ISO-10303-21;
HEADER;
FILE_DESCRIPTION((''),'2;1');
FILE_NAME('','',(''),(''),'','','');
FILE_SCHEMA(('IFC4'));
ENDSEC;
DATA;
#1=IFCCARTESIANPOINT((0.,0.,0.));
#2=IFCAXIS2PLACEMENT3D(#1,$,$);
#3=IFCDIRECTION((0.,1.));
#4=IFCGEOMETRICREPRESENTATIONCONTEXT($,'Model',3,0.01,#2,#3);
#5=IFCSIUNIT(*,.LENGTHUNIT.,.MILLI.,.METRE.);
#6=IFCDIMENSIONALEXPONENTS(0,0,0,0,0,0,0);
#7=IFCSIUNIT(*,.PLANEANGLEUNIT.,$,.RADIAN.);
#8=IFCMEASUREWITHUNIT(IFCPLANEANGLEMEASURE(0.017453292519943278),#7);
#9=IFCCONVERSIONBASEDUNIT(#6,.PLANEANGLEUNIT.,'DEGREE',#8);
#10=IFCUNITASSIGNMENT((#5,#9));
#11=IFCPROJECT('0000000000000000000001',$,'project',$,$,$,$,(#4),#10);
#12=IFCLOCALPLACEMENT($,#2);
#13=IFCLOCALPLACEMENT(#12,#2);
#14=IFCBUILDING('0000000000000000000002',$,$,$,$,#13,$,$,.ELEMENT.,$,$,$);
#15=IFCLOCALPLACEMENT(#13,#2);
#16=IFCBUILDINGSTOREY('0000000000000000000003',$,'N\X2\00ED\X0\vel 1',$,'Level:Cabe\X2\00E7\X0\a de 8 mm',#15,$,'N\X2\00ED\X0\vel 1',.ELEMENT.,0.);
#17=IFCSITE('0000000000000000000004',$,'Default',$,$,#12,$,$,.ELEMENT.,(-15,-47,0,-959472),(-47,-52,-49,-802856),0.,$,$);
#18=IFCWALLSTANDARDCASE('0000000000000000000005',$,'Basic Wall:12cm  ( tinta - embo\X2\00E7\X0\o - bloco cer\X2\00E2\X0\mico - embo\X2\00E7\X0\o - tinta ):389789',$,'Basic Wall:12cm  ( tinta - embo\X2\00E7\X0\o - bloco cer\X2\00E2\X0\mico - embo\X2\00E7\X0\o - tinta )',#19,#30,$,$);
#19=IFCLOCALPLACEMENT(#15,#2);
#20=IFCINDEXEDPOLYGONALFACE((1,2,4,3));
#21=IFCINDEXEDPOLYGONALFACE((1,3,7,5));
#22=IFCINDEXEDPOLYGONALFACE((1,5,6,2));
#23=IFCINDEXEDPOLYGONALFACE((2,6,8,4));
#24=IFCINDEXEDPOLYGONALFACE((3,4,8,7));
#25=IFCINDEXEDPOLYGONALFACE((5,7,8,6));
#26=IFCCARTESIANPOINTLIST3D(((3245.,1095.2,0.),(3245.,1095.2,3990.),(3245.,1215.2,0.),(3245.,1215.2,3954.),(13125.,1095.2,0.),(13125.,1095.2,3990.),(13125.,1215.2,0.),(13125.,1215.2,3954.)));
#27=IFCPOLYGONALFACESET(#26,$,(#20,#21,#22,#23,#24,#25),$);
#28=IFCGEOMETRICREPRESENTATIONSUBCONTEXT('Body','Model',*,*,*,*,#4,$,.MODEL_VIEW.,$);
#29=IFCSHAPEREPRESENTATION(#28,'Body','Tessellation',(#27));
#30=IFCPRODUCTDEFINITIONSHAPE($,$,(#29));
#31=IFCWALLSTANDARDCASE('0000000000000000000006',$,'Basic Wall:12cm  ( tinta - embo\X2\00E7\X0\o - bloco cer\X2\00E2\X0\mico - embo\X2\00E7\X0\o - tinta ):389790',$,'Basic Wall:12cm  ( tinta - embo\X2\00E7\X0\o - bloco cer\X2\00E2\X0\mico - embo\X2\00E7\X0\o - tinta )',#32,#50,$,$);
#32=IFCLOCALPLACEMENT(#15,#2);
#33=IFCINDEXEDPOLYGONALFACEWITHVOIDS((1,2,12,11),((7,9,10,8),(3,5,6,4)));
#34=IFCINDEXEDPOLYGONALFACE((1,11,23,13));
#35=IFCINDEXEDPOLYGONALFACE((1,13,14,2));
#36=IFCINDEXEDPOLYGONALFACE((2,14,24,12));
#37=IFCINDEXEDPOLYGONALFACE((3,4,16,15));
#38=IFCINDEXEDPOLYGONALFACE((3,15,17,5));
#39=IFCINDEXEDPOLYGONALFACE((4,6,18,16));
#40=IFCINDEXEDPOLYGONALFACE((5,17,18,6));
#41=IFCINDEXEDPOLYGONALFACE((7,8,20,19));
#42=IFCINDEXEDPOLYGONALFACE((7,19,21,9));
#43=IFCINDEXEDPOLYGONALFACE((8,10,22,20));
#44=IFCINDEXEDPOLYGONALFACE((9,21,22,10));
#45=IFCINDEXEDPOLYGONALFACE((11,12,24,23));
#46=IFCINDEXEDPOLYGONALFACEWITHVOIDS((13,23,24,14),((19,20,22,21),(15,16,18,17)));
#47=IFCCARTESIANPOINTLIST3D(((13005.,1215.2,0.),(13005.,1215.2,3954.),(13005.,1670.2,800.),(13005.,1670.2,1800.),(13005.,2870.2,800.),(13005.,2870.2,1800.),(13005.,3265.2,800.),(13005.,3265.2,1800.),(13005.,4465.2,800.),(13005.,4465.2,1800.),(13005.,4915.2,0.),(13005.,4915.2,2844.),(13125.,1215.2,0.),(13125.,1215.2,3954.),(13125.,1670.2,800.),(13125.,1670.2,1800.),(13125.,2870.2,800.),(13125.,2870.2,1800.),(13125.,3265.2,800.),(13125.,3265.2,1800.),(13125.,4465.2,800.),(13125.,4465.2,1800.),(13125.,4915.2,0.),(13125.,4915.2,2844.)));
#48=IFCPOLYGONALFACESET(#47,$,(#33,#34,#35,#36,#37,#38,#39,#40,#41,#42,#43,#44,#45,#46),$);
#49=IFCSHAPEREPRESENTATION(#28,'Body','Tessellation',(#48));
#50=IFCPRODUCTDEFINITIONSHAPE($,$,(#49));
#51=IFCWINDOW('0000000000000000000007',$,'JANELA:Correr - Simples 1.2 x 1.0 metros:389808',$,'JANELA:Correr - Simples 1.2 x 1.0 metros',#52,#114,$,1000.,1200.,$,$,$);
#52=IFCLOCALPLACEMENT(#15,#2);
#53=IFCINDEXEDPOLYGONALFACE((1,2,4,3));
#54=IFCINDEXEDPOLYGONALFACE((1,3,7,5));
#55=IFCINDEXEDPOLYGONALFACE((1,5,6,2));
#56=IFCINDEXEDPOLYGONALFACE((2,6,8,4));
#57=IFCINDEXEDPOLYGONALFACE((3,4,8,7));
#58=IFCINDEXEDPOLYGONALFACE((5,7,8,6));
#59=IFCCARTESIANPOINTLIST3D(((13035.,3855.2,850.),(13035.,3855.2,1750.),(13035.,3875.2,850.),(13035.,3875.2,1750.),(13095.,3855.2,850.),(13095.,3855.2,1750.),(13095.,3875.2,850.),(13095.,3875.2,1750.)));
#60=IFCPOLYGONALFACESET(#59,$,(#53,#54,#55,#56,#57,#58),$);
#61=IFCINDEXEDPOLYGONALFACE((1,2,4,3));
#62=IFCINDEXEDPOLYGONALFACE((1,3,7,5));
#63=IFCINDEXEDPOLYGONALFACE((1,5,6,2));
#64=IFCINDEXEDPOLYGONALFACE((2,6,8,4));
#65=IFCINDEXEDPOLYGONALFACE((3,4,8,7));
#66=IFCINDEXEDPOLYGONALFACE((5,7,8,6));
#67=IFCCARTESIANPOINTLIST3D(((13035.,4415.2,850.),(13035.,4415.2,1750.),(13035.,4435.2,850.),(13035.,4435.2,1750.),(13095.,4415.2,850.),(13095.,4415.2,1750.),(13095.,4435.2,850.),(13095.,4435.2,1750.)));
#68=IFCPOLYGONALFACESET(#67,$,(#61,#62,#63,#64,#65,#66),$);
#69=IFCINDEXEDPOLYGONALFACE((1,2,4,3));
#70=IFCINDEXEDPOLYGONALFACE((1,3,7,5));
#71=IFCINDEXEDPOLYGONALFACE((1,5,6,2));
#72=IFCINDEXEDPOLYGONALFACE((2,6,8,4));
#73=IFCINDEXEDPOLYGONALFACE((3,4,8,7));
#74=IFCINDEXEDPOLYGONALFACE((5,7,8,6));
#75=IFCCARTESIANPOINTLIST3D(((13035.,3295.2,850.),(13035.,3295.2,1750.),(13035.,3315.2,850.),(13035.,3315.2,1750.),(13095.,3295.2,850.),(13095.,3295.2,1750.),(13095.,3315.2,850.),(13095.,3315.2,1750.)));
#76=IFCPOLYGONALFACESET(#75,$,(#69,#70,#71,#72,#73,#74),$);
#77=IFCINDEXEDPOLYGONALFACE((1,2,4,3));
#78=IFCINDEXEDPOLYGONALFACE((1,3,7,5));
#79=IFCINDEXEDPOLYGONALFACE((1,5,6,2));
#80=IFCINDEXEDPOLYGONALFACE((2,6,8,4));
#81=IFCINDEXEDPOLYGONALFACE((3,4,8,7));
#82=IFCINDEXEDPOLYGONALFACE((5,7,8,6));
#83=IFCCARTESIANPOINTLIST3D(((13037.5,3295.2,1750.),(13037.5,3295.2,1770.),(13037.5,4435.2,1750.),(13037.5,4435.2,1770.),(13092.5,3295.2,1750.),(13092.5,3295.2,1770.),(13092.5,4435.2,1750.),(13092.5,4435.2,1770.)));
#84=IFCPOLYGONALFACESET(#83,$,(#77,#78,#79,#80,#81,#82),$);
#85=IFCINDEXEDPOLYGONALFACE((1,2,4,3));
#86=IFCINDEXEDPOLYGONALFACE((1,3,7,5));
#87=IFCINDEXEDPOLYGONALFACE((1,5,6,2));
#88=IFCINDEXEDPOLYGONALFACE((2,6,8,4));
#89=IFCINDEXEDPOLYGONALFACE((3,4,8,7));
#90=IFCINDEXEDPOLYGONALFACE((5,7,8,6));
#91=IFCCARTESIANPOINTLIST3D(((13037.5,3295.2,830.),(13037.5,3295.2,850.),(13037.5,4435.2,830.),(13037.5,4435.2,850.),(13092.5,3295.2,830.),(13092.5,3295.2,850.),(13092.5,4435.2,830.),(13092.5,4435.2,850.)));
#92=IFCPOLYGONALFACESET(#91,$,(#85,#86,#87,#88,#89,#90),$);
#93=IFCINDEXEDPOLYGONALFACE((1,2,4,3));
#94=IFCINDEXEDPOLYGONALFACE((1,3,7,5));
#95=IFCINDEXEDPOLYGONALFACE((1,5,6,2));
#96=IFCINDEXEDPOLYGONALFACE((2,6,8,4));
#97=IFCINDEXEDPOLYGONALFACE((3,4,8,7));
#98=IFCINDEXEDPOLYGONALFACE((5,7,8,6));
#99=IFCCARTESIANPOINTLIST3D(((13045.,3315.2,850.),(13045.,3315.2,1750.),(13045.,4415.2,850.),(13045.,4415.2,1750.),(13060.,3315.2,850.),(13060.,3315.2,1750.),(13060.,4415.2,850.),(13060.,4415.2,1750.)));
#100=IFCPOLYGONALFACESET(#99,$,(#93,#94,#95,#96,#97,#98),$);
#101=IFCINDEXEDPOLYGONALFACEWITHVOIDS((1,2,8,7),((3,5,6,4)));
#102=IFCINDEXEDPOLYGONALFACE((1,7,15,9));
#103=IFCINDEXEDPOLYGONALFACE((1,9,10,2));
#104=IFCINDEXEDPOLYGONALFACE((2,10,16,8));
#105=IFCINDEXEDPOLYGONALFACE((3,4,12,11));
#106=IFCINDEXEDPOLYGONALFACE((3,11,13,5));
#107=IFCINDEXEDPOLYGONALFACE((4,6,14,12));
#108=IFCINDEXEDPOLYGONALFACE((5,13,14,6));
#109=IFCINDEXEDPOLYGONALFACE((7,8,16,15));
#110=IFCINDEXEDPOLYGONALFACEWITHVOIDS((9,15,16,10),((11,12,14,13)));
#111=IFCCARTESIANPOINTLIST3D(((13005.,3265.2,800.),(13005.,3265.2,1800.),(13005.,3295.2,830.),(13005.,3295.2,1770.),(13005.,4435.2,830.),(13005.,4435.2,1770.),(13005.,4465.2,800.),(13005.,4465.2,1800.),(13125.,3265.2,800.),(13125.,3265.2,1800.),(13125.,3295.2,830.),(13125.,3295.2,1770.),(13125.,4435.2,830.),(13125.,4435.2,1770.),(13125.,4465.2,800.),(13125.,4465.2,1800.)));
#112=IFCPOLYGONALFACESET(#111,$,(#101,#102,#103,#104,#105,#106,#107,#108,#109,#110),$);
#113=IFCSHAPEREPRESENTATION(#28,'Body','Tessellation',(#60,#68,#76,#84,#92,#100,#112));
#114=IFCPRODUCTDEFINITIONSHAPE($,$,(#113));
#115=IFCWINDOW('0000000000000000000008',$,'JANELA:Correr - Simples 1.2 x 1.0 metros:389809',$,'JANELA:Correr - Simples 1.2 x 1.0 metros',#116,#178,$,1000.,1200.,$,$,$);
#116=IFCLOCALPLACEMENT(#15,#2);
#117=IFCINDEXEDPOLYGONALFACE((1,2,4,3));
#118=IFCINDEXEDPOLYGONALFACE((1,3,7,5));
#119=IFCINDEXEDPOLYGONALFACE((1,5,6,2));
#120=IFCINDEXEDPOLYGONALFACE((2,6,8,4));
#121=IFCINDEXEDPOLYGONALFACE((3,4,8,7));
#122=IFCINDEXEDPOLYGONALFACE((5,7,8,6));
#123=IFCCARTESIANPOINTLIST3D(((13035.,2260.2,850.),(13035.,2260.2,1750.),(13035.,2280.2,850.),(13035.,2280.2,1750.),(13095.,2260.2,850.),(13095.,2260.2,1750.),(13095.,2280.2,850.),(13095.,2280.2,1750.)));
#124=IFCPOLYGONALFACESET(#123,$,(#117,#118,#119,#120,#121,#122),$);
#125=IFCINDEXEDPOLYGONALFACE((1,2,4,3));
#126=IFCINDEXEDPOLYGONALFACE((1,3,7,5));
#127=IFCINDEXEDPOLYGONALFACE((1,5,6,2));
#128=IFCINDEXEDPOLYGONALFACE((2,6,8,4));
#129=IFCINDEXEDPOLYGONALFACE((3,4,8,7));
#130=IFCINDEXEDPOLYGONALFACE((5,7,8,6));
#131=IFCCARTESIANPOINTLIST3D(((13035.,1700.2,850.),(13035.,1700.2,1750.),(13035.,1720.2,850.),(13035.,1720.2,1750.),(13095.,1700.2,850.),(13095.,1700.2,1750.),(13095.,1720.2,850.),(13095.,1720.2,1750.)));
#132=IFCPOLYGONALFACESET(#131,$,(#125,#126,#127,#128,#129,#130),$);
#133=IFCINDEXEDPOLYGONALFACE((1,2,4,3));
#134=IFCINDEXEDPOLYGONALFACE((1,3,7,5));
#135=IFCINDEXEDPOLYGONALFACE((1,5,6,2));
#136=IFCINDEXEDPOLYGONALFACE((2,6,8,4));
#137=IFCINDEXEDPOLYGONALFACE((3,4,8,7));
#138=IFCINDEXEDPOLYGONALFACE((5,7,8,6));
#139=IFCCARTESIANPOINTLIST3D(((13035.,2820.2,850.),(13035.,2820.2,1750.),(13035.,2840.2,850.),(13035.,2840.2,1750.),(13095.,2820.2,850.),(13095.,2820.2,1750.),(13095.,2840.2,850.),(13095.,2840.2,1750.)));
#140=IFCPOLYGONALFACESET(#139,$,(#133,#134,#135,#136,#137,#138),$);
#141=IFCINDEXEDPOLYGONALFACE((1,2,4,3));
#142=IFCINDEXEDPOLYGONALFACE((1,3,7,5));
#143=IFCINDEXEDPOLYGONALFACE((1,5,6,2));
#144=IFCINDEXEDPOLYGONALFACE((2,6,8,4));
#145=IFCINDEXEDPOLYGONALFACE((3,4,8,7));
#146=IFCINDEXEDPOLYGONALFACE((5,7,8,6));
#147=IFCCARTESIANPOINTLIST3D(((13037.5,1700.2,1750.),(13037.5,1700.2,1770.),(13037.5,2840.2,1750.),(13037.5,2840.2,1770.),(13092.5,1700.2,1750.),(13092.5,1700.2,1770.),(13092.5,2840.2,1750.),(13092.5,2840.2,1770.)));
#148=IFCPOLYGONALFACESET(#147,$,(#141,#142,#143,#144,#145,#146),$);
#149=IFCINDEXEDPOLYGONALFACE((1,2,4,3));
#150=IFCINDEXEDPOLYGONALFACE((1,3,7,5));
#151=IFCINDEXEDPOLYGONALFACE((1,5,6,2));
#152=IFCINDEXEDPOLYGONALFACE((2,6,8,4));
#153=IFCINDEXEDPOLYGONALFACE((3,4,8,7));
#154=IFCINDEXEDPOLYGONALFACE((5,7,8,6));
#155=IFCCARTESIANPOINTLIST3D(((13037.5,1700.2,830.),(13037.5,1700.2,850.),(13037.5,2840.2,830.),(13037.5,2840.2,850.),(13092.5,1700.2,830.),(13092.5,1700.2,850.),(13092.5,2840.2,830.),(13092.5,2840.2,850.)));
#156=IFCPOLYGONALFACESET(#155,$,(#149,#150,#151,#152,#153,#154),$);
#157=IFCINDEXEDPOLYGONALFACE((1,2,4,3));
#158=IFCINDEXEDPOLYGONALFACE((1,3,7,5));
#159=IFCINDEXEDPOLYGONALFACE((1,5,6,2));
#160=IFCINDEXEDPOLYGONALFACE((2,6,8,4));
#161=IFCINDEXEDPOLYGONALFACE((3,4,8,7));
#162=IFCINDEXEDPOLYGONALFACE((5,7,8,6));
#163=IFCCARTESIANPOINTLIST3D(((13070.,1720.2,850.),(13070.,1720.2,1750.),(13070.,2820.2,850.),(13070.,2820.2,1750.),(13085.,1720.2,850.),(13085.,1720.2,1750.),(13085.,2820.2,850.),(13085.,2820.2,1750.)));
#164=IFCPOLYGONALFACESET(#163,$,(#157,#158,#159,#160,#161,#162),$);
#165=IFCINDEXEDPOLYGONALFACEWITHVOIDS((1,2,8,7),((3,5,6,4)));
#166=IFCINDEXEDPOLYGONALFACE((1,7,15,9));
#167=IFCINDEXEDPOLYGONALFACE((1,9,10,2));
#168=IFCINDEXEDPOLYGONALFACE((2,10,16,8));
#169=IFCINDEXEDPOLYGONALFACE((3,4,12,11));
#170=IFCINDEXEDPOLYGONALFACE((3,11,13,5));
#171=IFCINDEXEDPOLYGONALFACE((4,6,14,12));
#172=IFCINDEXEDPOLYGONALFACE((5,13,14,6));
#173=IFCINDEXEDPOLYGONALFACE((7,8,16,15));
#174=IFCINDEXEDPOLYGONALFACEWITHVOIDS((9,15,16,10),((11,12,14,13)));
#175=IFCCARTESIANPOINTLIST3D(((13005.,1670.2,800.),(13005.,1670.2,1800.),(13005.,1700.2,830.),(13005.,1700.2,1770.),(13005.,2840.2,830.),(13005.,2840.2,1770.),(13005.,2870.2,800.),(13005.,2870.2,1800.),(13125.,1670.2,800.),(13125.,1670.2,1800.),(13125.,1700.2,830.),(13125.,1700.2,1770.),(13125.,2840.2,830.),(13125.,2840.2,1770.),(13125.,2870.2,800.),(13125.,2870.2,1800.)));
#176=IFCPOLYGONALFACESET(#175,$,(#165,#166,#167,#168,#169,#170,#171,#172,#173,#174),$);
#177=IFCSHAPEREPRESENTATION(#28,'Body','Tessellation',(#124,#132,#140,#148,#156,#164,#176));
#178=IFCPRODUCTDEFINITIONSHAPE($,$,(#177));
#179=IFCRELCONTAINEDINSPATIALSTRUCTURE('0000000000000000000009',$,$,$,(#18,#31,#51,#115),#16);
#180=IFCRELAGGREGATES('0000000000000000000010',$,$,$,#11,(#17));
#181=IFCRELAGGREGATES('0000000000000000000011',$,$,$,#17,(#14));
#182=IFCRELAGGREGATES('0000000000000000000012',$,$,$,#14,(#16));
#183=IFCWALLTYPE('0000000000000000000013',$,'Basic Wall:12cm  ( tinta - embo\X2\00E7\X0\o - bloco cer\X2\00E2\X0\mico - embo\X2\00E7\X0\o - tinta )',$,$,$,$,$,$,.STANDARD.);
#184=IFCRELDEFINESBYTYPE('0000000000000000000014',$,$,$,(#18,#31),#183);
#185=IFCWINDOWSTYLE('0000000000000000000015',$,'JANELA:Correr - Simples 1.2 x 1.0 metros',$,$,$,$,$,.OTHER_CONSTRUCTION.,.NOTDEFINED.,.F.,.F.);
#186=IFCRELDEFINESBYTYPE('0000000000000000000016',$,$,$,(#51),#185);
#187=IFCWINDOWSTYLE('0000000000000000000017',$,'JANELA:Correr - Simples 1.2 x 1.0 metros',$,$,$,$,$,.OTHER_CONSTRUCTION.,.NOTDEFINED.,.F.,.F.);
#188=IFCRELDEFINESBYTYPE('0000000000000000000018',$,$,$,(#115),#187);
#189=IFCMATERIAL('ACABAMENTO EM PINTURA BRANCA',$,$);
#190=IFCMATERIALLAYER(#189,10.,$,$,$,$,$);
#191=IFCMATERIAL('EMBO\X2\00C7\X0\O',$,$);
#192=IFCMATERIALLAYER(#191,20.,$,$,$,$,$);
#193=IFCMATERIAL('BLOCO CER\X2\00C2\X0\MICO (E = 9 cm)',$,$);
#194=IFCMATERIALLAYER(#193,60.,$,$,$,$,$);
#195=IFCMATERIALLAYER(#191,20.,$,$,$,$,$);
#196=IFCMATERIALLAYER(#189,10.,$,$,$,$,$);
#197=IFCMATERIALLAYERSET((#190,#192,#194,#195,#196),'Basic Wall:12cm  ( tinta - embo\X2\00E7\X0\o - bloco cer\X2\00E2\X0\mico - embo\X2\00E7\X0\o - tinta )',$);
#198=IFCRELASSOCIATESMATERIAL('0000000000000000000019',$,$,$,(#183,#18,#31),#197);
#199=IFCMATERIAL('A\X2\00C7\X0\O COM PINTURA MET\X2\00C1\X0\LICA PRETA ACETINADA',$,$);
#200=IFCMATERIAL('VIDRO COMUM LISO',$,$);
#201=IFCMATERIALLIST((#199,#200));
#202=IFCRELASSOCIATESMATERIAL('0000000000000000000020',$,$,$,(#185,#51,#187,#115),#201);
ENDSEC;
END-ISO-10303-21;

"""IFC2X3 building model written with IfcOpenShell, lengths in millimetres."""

from ifc_helpers import new_model, entity, si_unit, converted_unit, direction, frame, frame_2d, origin, origin_2d_with_axis, place, context, subcontext, project, spatial, polyline, rectangle, outline, extrude, clip, bounded_halfspace, source, transform, mapped, material, material_list, layer, layer_set, layer_usage, type_object, type_shapes, element, fill, save


model = new_model("IFC2X3")

# Units and contexts
model_context = context("Model", 3, precision=0.01, world=origin(), true_north=direction((0.0, 1.0)))
body_context = subcontext(model_context, "Body", "Model", "MODEL_VIEW")
ifc_project = project(units=[si_unit("LENGTHUNIT", "METRE", prefix="MILLI"), converted_unit("PLANEANGLEUNIT", "DEGREE", entity("IfcPlaneAngleMeasure", 0.017453292519943278), si_unit("PLANEANGLEUNIT", "RADIAN"), dimensions=[0, 0, 0, 0, 0, 0, 0])], contexts=[model_context])

# Site, building, storey
site_placement = place(None, origin())
site = spatial("IfcSite", under=ifc_project, at=site_placement, Name="Default", CompositionType="ELEMENT", RefLatitude=(-15, -47, 0, -959472), RefLongitude=(-47, -52, -49, -802856), RefElevation=0.0)
building_placement = place(site_placement, origin())
building = spatial("IfcBuilding", under=site, at=building_placement, CompositionType="ELEMENT")
storey_placement = place(building_placement, origin())
storey = spatial("IfcBuildingStorey", under=building, at=storey_placement, Name="Nível 1", ObjectType="Level:Cabeça de 8 mm", LongName="Nível 1", CompositionType="ELEMENT", Elevation=0.0)

# Wall
ifc_material_1 = material(Name="ACABAMENTO EM PINTURA BRANCA")
ifc_layer_1 = layer(ifc_material_1, 10.0)
ifc_material_2 = material(Name="EMBOÇO")
ifc_layer_2 = layer(ifc_material_2, 20.0)
ifc_material_3 = material(Name="BLOCO CERÂMICO (E = 9 cm)")
ifc_layer_3 = layer(ifc_material_3, 60.0)
ifc_layer_4 = layer(ifc_material_2, 20.0)
ifc_layer_5 = layer(ifc_material_1, 10.0)
ifc_layer_set_1 = layer_set([ifc_layer_1, ifc_layer_2, ifc_layer_3, ifc_layer_4, ifc_layer_5], Name="Basic Wall:12cm  ( tinta - emboço - bloco cerâmico - emboço - tinta )")
ifc_layer_usage_1 = layer_usage(ifc_layer_set_1, "AXIS2", "NEGATIVE", 60.0)
wall_type_1 = type_object("IfcWallType", Name="Basic Wall:12cm  ( tinta - emboço - bloco cerâmico - emboço - tinta )", PredefinedType="STANDARD", material=ifc_layer_set_1)
wall_1_placement = place(storey_placement, frame((13125.0, 1155.2, 0.0), z_axis=(0.0, 0.0, 1.0), x_axis=(-1.0, 0.0, 0.0)))
element("IfcWallStandardCase", 1, at=wall_1_placement, inside=storey, type_object=wall_type_1, material=ifc_layer_usage_1, Name="Basic Wall:12cm  ( tinta - emboço - bloco cerâmico - emboço - tinta ):389789", ObjectType="Basic Wall:12cm  ( tinta - emboço - bloco cerâmico - emboço - tinta )", context=body_context, shape_type="Clipping", body=[
    clip(extrude(rectangle(XDim=9880.0, YDim=120.0, at=frame_2d((4940.0, 0.0), x_axis=(-1.0, 0.0))), origin(), (0.0, 0.0, 1.0), 3990.0), bounded_halfspace(frame((0.0, -60.0, 3954.0), z_axis=(0.0, -0.287348, 0.957826), x_axis=(1.0, 0.0, 0.0)), False, frame((0.0, -60.0, 3954.0)), polyline([(0.0, 0.0), (120.0, 0.0), (9880.0, 0.0), (9880.0, 120.0), (0.0, 120.0), (0.0, 0.0)]))),
])

# Wall, openings, windows
ifc_layer_usage_2 = layer_usage(ifc_layer_set_1, "AXIS2", "NEGATIVE", 60.0)
wall_2_placement = place(storey_placement, frame((13065.0, 1215.2, 0.0), z_axis=(0.0, 0.0, 1.0), x_axis=(0.0, 1.0, 0.0)))
wall_2 = element("IfcWallStandardCase", 2, at=wall_2_placement, inside=storey, type_object=wall_type_1, material=ifc_layer_usage_2, Name="Basic Wall:12cm  ( tinta - emboço - bloco cerâmico - emboço - tinta ):389790", ObjectType="Basic Wall:12cm  ( tinta - emboço - bloco cerâmico - emboço - tinta )", context=body_context, shape_type="Clipping", body=[
    clip(extrude(rectangle(XDim=3700.0, YDim=120.0, at=frame_2d((1850.0, 0.0), x_axis=(-1.0, 0.0))), origin(), (0.0, 0.0, 1.0), 3954.0), bounded_halfspace(frame((0.0, -60.0, 3954.0), z_axis=(0.287348, 0.0, 0.957826), x_axis=(0.0, 1.0, 0.0)), False, frame((0.0, -60.0, 3954.0)), polyline([(0.0, 0.0), (3700.0, 0.0), (3700.0, 120.0), (0.0, 120.0), (0.0, 0.0)]))),
])
opening_1_placement = place(wall_2_placement, frame((3250.0, 60.0, 800.0)))
opening_1 = element("IfcOpeningElement", 3, at=opening_1_placement, cuts=wall_2, ObjectType="Opening", context=body_context, shape_type="SweptSolid", body=[
    extrude(rectangle(XDim=1000.0, YDim=1200.0, at=frame_2d((500.0, 600.0), x_axis=(1.0, 0.0))), frame((0.0, 0.0, 0.0), z_axis=(0.0, -1.0, 0.0), x_axis=(0.0, 0.0, 1.0)), (0.0, 0.0, 1.0), 120.0),
])
opening_2_placement = place(wall_2_placement, frame((455.0, -60.0, 800.0)))
opening_2 = element("IfcOpeningElement", 4, at=opening_2_placement, cuts=wall_2, ObjectType="Opening", context=body_context, shape_type="SweptSolid", body=[
    extrude(rectangle(XDim=1000.0, YDim=1200.0, at=frame_2d((500.0, 600.0), x_axis=(1.0, 0.0))), frame((0.0, 0.0, 0.0), z_axis=(0.0, 1.0, 0.0), x_axis=(0.0, 0.0, 1.0)), (0.0, 0.0, 1.0), 120.0),
])
ifc_material_4 = material(Name="AÇO COM PINTURA METÁLICA PRETA ACETINADA")
ifc_material_5 = material(Name="VIDRO COMUM LISO")
ifc_material_list_1 = material_list([ifc_material_4, ifc_material_5])
window_style_1 = type_object("IfcWindowStyle", Name="JANELA:Correr - Simples 1.2 x 1.0 metros", ConstructionType="OTHER_CONSTRUCTION", OperationType="NOTDEFINED", ParameterTakesPrecedence=False, Sizeable=False, material=ifc_material_list_1)
shared_shape_1 = source(origin(), body_context, "Body", "SweptSolid", [
    extrude(rectangle(XDim=20.0, YDim=60.0, at=origin_2d_with_axis()), frame((600.0, 60.0, 50.0), z_axis=(0.0, 0.0, 1.0), x_axis=(-1.0, 0.0, 0.0)), (0.0, 0.0, 1.0), 900.0),
    extrude(rectangle(XDim=20.0, YDim=60.0, at=frame_2d((0.0, 0.0), x_axis=(1.0, 0.0))), frame((40.0, 60.0, 50.0), z_axis=(0.0, 0.0, 1.0), x_axis=(-1.0, 0.0, 0.0)), (0.0, 0.0, 1.0), 900.0),
    extrude(rectangle(XDim=20.0, YDim=60.0, at=frame_2d((0.0, 0.0), x_axis=(1.0, 0.0))), frame((1160.0, 60.0, 50.0), z_axis=(0.0, 0.0, 1.0), x_axis=(-1.0, 0.0, 0.0)), (0.0, 0.0, 1.0), 900.0),
    extrude(rectangle(XDim=1140.0, YDim=55.0, at=origin_2d_with_axis()), frame((600.0, 60.0, 950.0), z_axis=(0.0, 0.0, 1.0), x_axis=(-1.0, 0.0, 0.0)), (0.0, 0.0, 1.0), 20.0),
    extrude(rectangle(XDim=1140.0, YDim=55.0, at=origin_2d_with_axis()), frame((600.0, 60.0, 30.0), z_axis=(0.0, 0.0, 1.0), x_axis=(-1.0, 0.0, 0.0)), (0.0, 0.0, 1.0), 20.0),
    extrude(rectangle(XDim=15.0, YDim=1100.0, at=frame_2d((0.0, 0.0), x_axis=(1.0, 0.0))), frame((600.0, 47.5, 50.0), z_axis=(0.0, 0.0, 1.0), x_axis=(0.0, 1.0, 0.0)), (0.0, 0.0, 1.0), 900.0),
    extrude(outline(polyline([(-600.0, -500.0), (600.0, -500.0), (600.0, 500.0), (-600.0, 500.0), (-600.0, -500.0)]), holes=[polyline([(570.0, -470.0), (-570.0, -470.0), (-570.0, 470.0), (570.0, 470.0), (570.0, -470.0)])]), frame((600.0, 0.0, 500.0), z_axis=(0.0, 1.0, 0.0), x_axis=(1.0, 0.0, 0.0)), (0.0, 0.0, 1.0), 120.0),
])
type_shapes(window_style_1, [shared_shape_1])
window_1_placement = place(opening_1_placement, frame((0.0, 0.0, 0.0), z_axis=(0.0, 0.0, 1.0), x_axis=(-1.0, 0.0, 0.0)))
window_1 = element("IfcWindow", 5, at=window_1_placement, inside=storey, type_object=window_style_1, material=ifc_material_list_1, Name="JANELA:Correr - Simples 1.2 x 1.0 metros:389808", ObjectType="JANELA:Correr - Simples 1.2 x 1.0 metros", OverallHeight=1000.0, OverallWidth=1200.0, context=body_context, shape_type="MappedRepresentation", body=[
    mapped(shared_shape_1, transform((0.0, 0.0, 0.0), scale=1.0)),
])
fill(opening_1, window_1)
window_style_2 = type_object("IfcWindowStyle", Name="JANELA:Correr - Simples 1.2 x 1.0 metros", ConstructionType="OTHER_CONSTRUCTION", OperationType="NOTDEFINED", ParameterTakesPrecedence=False, Sizeable=False, material=ifc_material_list_1)
shared_shape_2 = source(origin(), body_context, "Body", "SweptSolid", [
    extrude(rectangle(XDim=20.0, YDim=60.0, at=origin_2d_with_axis()), frame((600.0, 60.0, 50.0), z_axis=(0.0, 0.0, 1.0), x_axis=(-1.0, 0.0, 0.0)), (0.0, 0.0, 1.0), 900.0),
    extrude(rectangle(XDim=20.0, YDim=60.0, at=frame_2d((0.0, 0.0), x_axis=(1.0, 0.0))), frame((40.0, 60.0, 50.0), z_axis=(0.0, 0.0, 1.0), x_axis=(-1.0, 0.0, 0.0)), (0.0, 0.0, 1.0), 900.0),
    extrude(rectangle(XDim=20.0, YDim=60.0, at=frame_2d((0.0, 0.0), x_axis=(1.0, 0.0))), frame((1160.0, 60.0, 50.0), z_axis=(0.0, 0.0, 1.0), x_axis=(-1.0, 0.0, 0.0)), (0.0, 0.0, 1.0), 900.0),
    extrude(rectangle(XDim=1140.0, YDim=55.0, at=origin_2d_with_axis()), frame((600.0, 60.0, 950.0), z_axis=(0.0, 0.0, 1.0), x_axis=(-1.0, 0.0, 0.0)), (0.0, 0.0, 1.0), 20.0),
    extrude(rectangle(XDim=1140.0, YDim=55.0, at=origin_2d_with_axis()), frame((600.0, 60.0, 30.0), z_axis=(0.0, 0.0, 1.0), x_axis=(-1.0, 0.0, 0.0)), (0.0, 0.0, 1.0), 20.0),
    extrude(rectangle(XDim=15.0, YDim=1100.0, at=frame_2d((0.0, 0.0), x_axis=(1.0, 0.0))), frame((600.0, 47.5, 50.0), z_axis=(0.0, 0.0, 1.0), x_axis=(0.0, 1.0, 0.0)), (0.0, 0.0, 1.0), 900.0),
    extrude(outline(polyline([(-600.0, -500.0), (600.0, -500.0), (600.0, 500.0), (-600.0, 500.0), (-600.0, -500.0)]), holes=[polyline([(570.0, -470.0), (-570.0, -470.0), (-570.0, 470.0), (570.0, 470.0), (570.0, -470.0)])]), frame((600.0, 0.0, 500.0), z_axis=(0.0, 1.0, 0.0), x_axis=(1.0, 0.0, 0.0)), (0.0, 0.0, 1.0), 120.0),
])
type_shapes(window_style_2, [shared_shape_2])
window_2_placement = place(opening_2_placement, origin())
window_2 = element("IfcWindow", 6, at=window_2_placement, inside=storey, type_object=window_style_2, material=ifc_material_list_1, Name="JANELA:Correr - Simples 1.2 x 1.0 metros:389809", ObjectType="JANELA:Correr - Simples 1.2 x 1.0 metros", OverallHeight=1000.0, OverallWidth=1200.0, context=body_context, shape_type="MappedRepresentation", body=[
    mapped(shared_shape_2, transform((0.0, 0.0, 0.0), scale=1.0)),
])
fill(opening_2, window_2)

save(model, "model.ifc")
